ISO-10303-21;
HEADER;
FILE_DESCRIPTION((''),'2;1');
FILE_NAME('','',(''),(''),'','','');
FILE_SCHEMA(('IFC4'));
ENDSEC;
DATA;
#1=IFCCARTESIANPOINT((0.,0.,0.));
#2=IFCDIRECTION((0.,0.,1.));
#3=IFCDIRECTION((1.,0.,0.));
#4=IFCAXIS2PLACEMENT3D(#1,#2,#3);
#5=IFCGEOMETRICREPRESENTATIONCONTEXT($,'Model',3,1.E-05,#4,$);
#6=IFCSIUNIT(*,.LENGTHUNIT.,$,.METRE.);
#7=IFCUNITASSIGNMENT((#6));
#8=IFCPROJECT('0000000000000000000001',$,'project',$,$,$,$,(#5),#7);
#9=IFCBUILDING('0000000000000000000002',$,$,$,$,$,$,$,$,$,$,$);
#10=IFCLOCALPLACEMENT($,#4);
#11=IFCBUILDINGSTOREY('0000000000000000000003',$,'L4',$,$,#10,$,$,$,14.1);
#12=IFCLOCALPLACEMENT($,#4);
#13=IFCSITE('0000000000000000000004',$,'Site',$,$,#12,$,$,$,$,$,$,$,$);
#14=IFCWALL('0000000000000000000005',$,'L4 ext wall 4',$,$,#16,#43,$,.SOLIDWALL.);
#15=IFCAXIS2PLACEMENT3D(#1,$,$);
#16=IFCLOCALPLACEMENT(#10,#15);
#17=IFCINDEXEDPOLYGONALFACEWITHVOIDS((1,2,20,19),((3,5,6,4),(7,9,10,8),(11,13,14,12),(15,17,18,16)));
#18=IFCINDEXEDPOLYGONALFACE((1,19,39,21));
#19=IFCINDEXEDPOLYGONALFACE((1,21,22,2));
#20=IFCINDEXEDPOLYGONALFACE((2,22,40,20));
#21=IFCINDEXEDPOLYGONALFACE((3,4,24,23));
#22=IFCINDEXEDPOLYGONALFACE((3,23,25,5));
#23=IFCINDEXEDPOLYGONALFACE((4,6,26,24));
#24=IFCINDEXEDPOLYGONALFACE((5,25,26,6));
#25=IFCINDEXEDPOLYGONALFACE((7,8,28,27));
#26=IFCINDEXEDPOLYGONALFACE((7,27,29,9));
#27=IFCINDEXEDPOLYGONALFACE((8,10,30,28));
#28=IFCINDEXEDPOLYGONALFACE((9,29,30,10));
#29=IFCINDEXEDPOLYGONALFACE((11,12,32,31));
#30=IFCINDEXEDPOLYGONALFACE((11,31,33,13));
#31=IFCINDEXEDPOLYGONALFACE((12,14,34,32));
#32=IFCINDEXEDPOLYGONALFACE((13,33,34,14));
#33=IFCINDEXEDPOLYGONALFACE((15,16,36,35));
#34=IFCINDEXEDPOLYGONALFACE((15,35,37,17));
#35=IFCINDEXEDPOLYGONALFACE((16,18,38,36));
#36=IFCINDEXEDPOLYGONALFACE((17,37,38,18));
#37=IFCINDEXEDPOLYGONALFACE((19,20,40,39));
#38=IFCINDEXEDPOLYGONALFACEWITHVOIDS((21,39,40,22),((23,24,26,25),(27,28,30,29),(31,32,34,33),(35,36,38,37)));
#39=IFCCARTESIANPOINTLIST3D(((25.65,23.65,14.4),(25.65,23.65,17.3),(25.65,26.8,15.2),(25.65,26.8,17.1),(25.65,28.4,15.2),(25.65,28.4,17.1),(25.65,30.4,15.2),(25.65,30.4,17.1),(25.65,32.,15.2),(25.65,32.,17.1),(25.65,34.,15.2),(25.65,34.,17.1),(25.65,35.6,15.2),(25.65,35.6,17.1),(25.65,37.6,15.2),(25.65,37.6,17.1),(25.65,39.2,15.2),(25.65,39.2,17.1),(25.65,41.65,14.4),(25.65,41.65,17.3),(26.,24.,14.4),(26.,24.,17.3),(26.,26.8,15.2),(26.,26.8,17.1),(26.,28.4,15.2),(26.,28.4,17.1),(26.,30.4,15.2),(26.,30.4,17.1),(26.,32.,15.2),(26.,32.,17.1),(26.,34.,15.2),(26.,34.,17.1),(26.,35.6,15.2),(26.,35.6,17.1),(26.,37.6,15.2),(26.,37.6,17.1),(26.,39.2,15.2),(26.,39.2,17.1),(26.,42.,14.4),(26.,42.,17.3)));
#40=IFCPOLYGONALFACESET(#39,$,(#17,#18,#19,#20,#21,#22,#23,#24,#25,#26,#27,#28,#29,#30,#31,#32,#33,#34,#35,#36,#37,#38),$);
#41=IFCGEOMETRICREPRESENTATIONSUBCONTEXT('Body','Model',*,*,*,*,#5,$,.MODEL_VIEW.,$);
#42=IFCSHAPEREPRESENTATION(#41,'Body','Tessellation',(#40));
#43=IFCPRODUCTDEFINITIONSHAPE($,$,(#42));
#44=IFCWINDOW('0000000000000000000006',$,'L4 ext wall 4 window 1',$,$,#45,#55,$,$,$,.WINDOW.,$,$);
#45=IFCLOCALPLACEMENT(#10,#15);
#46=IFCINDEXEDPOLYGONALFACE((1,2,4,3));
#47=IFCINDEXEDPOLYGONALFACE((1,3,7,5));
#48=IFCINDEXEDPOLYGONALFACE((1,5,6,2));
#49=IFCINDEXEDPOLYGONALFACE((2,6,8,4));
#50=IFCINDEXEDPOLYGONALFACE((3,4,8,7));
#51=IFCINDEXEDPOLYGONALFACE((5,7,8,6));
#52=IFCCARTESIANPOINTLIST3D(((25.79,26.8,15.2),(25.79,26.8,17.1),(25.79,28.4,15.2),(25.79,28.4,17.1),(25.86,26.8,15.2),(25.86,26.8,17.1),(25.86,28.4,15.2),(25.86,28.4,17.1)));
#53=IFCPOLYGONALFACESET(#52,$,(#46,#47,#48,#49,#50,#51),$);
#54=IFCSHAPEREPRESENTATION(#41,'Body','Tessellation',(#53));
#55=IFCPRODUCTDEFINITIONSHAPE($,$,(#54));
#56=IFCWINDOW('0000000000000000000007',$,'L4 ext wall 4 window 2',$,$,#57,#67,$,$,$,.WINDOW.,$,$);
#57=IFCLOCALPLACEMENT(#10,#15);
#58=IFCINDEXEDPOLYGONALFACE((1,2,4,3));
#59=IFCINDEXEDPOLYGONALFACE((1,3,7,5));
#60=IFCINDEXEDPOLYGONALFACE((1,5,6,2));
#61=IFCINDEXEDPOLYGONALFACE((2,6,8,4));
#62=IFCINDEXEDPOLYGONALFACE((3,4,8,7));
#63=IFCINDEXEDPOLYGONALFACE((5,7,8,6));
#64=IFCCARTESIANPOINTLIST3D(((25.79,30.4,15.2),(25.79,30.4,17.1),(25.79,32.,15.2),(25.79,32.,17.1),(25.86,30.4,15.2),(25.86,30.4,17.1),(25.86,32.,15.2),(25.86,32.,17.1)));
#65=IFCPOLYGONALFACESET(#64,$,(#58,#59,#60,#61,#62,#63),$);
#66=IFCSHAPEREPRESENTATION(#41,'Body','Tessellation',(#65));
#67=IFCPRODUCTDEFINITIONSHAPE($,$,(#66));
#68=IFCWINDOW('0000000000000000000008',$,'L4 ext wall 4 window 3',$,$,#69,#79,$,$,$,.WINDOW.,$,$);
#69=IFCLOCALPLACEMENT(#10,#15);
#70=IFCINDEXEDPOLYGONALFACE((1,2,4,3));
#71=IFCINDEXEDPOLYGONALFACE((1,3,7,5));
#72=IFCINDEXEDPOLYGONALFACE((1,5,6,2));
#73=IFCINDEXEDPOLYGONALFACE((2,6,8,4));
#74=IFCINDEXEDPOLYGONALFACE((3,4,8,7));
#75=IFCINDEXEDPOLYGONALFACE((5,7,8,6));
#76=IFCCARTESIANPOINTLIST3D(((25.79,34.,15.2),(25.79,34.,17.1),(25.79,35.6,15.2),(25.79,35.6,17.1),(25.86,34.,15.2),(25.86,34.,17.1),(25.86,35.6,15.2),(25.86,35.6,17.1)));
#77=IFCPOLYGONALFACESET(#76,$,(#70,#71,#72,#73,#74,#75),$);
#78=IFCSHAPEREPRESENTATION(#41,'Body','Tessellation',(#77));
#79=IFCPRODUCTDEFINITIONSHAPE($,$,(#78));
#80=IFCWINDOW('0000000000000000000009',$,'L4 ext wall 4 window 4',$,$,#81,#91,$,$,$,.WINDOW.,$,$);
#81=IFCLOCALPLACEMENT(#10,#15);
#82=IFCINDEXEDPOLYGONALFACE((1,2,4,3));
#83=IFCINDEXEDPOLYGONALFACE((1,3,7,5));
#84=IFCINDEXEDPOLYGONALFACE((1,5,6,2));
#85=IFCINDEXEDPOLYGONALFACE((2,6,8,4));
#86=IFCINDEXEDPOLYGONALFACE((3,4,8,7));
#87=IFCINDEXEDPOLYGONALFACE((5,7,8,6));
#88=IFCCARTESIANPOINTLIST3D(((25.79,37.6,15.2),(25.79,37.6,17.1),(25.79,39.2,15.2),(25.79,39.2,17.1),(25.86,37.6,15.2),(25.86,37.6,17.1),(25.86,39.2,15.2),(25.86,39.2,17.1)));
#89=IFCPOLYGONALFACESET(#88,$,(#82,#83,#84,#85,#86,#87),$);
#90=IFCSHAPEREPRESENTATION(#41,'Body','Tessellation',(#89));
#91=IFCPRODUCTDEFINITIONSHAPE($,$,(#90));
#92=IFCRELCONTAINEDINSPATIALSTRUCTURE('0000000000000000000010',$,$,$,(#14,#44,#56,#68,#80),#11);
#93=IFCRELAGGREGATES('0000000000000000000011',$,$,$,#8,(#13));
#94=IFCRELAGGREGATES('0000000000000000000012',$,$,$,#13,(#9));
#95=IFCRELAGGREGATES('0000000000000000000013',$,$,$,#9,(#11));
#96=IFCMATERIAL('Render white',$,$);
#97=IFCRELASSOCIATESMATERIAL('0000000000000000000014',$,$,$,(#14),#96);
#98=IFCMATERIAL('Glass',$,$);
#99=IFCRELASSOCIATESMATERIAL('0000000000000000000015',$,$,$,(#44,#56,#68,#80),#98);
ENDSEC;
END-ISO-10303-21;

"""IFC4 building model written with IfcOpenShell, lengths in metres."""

from ifc_helpers import new_model, si_unit, frame, origin_with_axes, place, context, subcontext, project, spatial, polyline, outline, extrude, material, element, fill, save


model = new_model("IFC4")

# Units and contexts
model_context = context("Model", 3, precision=1e-05, world=origin_with_axes())
body_context = subcontext(model_context, "Body", "Model", "MODEL_VIEW")
ifc_project = project(units=[si_unit("LENGTHUNIT", "METRE")], contexts=[model_context])

# Site, building, storey
site_placement = place(None, origin_with_axes())
site = spatial("IfcSite", under=ifc_project, at=site_placement, Name="Site")
building = spatial("IfcBuilding", under=site)
storey_placement = place(None, origin_with_axes())
storey = spatial("IfcBuildingStorey", under=building, at=storey_placement, Name="L4", Elevation=14.1)

# Wall, openings, windows
ifc_material_1 = material(Name="Render white")
ifc_material_2 = material(Name="Glass")
wall_1_placement = place(storey_placement, origin_with_axes())
wall_1 = element("IfcWall", 1, at=wall_1_placement, inside=storey, material=ifc_material_1, Name="L4 ext wall 4", PredefinedType="SOLIDWALL", context=body_context, shape_type="SweptSolid", body=[
    extrude(outline(polyline([(26.0, 24.0), (26.0, 42.0), (25.65, 41.65), (25.65, 23.65), (26.0, 24.0)])), frame((0.0, 0.0, 14.4), z_axis=(0.0, 0.0, 1.0), x_axis=(1.0, 0.0, 0.0)), (0.0, 0.0, 1.0), 2.9),
])
opening_1_placement = place(wall_1_placement, origin_with_axes())
opening_1 = element("IfcOpeningElement", 2, at=opening_1_placement, cuts=wall_1, context=body_context, shape_type="SweptSolid", body=[
    extrude(outline(polyline([(26.05, 26.8), (26.05, 28.4), (25.6, 28.4), (25.6, 26.8), (26.05, 26.8)])), frame((0.0, 0.0, 15.2), z_axis=(0.0, 0.0, 1.0), x_axis=(1.0, 0.0, 0.0)), (0.0, 0.0, 1.0), 1.9),
])
opening_2_placement = place(wall_1_placement, origin_with_axes())
opening_2 = element("IfcOpeningElement", 3, at=opening_2_placement, cuts=wall_1, context=body_context, shape_type="SweptSolid", body=[
    extrude(outline(polyline([(26.05, 30.4), (26.05, 32.0), (25.6, 32.0), (25.6, 30.4), (26.05, 30.4)])), frame((0.0, 0.0, 15.2), z_axis=(0.0, 0.0, 1.0), x_axis=(1.0, 0.0, 0.0)), (0.0, 0.0, 1.0), 1.9),
])
opening_3_placement = place(wall_1_placement, origin_with_axes())
opening_3 = element("IfcOpeningElement", 4, at=opening_3_placement, cuts=wall_1, context=body_context, shape_type="SweptSolid", body=[
    extrude(outline(polyline([(26.05, 34.0), (26.05, 35.6), (25.6, 35.6), (25.6, 34.0), (26.05, 34.0)])), frame((0.0, 0.0, 15.2), z_axis=(0.0, 0.0, 1.0), x_axis=(1.0, 0.0, 0.0)), (0.0, 0.0, 1.0), 1.9),
])
opening_4_placement = place(wall_1_placement, origin_with_axes())
opening_4 = element("IfcOpeningElement", 5, at=opening_4_placement, cuts=wall_1, context=body_context, shape_type="SweptSolid", body=[
    extrude(outline(polyline([(26.05, 37.6), (26.05, 39.2), (25.6, 39.2), (25.6, 37.6), (26.05, 37.6)])), frame((0.0, 0.0, 15.2), z_axis=(0.0, 0.0, 1.0), x_axis=(1.0, 0.0, 0.0)), (0.0, 0.0, 1.0), 1.9),
])
window_1_placement = place(storey_placement, origin_with_axes())
window_1 = element("IfcWindow", 6, at=window_1_placement, inside=storey, material=ifc_material_2, Name="L4 ext wall 4 window 1", PredefinedType="WINDOW", context=body_context, shape_type="SweptSolid", body=[
    extrude(outline(polyline([(25.86, 26.8), (25.86, 28.4), (25.79, 28.4), (25.79, 26.8), (25.86, 26.8)])), frame((0.0, 0.0, 15.2), z_axis=(0.0, 0.0, 1.0), x_axis=(1.0, 0.0, 0.0)), (0.0, 0.0, 1.0), 1.9),
])
fill(opening_1, window_1)
window_2_placement = place(storey_placement, origin_with_axes())
window_2 = element("IfcWindow", 7, at=window_2_placement, inside=storey, material=ifc_material_2, Name="L4 ext wall 4 window 2", PredefinedType="WINDOW", context=body_context, shape_type="SweptSolid", body=[
    extrude(outline(polyline([(25.86, 30.4), (25.86, 32.0), (25.79, 32.0), (25.79, 30.4), (25.86, 30.4)])), frame((0.0, 0.0, 15.2), z_axis=(0.0, 0.0, 1.0), x_axis=(1.0, 0.0, 0.0)), (0.0, 0.0, 1.0), 1.9),
])
fill(opening_2, window_2)
window_3_placement = place(storey_placement, origin_with_axes())
window_3 = element("IfcWindow", 8, at=window_3_placement, inside=storey, material=ifc_material_2, Name="L4 ext wall 4 window 3", PredefinedType="WINDOW", context=body_context, shape_type="SweptSolid", body=[
    extrude(outline(polyline([(25.86, 34.0), (25.86, 35.6), (25.79, 35.6), (25.79, 34.0), (25.86, 34.0)])), frame((0.0, 0.0, 15.2), z_axis=(0.0, 0.0, 1.0), x_axis=(1.0, 0.0, 0.0)), (0.0, 0.0, 1.0), 1.9),
])
fill(opening_3, window_3)
window_4_placement = place(storey_placement, origin_with_axes())
window_4 = element("IfcWindow", 9, at=window_4_placement, inside=storey, material=ifc_material_2, Name="L4 ext wall 4 window 4", PredefinedType="WINDOW", context=body_context, shape_type="SweptSolid", body=[
    extrude(outline(polyline([(25.86, 37.6), (25.86, 39.2), (25.79, 39.2), (25.79, 37.6), (25.86, 37.6)])), frame((0.0, 0.0, 15.2), z_axis=(0.0, 0.0, 1.0), x_axis=(1.0, 0.0, 0.0)), (0.0, 0.0, 1.0), 1.9),
])
fill(opening_4, window_4)

save(model, "model.ifc")
